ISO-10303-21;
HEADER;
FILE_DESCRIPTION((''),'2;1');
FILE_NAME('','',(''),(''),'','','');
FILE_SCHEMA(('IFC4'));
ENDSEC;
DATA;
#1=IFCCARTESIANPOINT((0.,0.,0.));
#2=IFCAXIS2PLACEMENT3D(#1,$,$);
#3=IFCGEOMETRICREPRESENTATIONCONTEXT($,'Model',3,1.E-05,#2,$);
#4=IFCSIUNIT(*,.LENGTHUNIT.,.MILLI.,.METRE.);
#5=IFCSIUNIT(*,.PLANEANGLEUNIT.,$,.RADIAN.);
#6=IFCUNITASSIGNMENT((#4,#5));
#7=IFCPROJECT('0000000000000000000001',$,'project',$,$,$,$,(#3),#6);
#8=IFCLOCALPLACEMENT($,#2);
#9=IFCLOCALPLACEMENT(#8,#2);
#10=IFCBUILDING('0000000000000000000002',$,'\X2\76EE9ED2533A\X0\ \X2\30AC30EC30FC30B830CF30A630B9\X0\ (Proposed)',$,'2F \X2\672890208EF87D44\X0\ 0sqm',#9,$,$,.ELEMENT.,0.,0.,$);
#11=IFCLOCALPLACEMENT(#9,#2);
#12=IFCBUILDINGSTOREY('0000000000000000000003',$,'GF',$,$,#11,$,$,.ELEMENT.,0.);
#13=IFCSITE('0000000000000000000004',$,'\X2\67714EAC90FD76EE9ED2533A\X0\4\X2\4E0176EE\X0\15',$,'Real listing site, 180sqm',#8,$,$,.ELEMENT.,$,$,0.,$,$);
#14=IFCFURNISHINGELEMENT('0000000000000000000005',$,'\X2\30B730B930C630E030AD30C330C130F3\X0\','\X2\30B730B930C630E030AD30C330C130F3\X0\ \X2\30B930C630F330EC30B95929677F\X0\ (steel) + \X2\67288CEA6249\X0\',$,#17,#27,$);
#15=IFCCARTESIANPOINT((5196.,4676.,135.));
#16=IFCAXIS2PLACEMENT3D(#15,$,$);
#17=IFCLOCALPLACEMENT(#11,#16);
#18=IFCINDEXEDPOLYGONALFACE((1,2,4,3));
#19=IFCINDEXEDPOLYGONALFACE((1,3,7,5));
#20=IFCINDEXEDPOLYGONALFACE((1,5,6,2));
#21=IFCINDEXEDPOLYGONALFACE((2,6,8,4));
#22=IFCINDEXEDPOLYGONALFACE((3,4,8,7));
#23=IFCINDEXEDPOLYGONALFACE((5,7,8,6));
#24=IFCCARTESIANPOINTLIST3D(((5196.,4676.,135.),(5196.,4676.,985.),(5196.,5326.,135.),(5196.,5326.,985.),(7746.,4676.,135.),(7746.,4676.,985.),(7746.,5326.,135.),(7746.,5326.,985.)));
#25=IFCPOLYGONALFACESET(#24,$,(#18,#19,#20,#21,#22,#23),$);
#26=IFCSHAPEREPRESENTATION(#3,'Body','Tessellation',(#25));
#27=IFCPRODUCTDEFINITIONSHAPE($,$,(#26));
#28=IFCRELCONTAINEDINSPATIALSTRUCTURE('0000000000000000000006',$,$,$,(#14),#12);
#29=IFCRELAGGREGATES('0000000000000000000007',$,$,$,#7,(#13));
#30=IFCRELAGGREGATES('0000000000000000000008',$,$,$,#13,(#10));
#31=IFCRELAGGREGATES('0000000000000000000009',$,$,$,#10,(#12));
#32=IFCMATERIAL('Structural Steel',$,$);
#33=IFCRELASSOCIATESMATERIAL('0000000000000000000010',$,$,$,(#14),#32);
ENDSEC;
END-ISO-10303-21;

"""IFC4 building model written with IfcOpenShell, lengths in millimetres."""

from ifc_helpers import new_model, si_unit, frame, frame_2d, origin, place, context, project, spatial, rectangle, extrude, material, element, save


model = new_model("IFC4")

# Units and contexts
model_context = context("Model", 3, precision=1e-05, world=origin())
ifc_project = project(units=[si_unit("LENGTHUNIT", "METRE", prefix="MILLI"), si_unit("PLANEANGLEUNIT", "RADIAN")], contexts=[model_context])

# Site, building, storey
site_placement = place(None, origin())
site = spatial("IfcSite", under=ifc_project, at=site_placement, Name="東京都目黒区4丁目15", ObjectType="Real listing site, 180sqm", CompositionType="ELEMENT", RefElevation=0.0)
building_placement = place(site_placement, origin())
building = spatial("IfcBuilding", under=site, at=building_placement, Name="目黒区 ガレージハウス (Proposed)", ObjectType="2F 木造軸組 0sqm", CompositionType="ELEMENT", ElevationOfRefHeight=0.0, ElevationOfTerrain=0.0)
storey_placement = place(building_placement, origin())
storey = spatial("IfcBuildingStorey", under=building, at=storey_placement, Name="GF", CompositionType="ELEMENT", Elevation=0.0)

# Furnishing element
ifc_material_1 = material(Name="Structural Steel")
furnishing_placement = place(storey_placement, frame((5196.0, 4676.0, 135.0)))
element("IfcFurnishingElement", 1, at=furnishing_placement, inside=storey, material=ifc_material_1, Name="システムキッチン", Description="システムキッチン ステンレス天板 (steel) + 木質扉", context=model_context, shape_type="SweptSolid", body=[
    extrude(rectangle(XDim=2550.0, YDim=650.0, at=frame_2d((1275.0, 325.0))), frame((5196.0, 4676.0, 135.0)), (0.0, 0.0, 1.0), 850.0),
])

save(model, "model.ifc")
